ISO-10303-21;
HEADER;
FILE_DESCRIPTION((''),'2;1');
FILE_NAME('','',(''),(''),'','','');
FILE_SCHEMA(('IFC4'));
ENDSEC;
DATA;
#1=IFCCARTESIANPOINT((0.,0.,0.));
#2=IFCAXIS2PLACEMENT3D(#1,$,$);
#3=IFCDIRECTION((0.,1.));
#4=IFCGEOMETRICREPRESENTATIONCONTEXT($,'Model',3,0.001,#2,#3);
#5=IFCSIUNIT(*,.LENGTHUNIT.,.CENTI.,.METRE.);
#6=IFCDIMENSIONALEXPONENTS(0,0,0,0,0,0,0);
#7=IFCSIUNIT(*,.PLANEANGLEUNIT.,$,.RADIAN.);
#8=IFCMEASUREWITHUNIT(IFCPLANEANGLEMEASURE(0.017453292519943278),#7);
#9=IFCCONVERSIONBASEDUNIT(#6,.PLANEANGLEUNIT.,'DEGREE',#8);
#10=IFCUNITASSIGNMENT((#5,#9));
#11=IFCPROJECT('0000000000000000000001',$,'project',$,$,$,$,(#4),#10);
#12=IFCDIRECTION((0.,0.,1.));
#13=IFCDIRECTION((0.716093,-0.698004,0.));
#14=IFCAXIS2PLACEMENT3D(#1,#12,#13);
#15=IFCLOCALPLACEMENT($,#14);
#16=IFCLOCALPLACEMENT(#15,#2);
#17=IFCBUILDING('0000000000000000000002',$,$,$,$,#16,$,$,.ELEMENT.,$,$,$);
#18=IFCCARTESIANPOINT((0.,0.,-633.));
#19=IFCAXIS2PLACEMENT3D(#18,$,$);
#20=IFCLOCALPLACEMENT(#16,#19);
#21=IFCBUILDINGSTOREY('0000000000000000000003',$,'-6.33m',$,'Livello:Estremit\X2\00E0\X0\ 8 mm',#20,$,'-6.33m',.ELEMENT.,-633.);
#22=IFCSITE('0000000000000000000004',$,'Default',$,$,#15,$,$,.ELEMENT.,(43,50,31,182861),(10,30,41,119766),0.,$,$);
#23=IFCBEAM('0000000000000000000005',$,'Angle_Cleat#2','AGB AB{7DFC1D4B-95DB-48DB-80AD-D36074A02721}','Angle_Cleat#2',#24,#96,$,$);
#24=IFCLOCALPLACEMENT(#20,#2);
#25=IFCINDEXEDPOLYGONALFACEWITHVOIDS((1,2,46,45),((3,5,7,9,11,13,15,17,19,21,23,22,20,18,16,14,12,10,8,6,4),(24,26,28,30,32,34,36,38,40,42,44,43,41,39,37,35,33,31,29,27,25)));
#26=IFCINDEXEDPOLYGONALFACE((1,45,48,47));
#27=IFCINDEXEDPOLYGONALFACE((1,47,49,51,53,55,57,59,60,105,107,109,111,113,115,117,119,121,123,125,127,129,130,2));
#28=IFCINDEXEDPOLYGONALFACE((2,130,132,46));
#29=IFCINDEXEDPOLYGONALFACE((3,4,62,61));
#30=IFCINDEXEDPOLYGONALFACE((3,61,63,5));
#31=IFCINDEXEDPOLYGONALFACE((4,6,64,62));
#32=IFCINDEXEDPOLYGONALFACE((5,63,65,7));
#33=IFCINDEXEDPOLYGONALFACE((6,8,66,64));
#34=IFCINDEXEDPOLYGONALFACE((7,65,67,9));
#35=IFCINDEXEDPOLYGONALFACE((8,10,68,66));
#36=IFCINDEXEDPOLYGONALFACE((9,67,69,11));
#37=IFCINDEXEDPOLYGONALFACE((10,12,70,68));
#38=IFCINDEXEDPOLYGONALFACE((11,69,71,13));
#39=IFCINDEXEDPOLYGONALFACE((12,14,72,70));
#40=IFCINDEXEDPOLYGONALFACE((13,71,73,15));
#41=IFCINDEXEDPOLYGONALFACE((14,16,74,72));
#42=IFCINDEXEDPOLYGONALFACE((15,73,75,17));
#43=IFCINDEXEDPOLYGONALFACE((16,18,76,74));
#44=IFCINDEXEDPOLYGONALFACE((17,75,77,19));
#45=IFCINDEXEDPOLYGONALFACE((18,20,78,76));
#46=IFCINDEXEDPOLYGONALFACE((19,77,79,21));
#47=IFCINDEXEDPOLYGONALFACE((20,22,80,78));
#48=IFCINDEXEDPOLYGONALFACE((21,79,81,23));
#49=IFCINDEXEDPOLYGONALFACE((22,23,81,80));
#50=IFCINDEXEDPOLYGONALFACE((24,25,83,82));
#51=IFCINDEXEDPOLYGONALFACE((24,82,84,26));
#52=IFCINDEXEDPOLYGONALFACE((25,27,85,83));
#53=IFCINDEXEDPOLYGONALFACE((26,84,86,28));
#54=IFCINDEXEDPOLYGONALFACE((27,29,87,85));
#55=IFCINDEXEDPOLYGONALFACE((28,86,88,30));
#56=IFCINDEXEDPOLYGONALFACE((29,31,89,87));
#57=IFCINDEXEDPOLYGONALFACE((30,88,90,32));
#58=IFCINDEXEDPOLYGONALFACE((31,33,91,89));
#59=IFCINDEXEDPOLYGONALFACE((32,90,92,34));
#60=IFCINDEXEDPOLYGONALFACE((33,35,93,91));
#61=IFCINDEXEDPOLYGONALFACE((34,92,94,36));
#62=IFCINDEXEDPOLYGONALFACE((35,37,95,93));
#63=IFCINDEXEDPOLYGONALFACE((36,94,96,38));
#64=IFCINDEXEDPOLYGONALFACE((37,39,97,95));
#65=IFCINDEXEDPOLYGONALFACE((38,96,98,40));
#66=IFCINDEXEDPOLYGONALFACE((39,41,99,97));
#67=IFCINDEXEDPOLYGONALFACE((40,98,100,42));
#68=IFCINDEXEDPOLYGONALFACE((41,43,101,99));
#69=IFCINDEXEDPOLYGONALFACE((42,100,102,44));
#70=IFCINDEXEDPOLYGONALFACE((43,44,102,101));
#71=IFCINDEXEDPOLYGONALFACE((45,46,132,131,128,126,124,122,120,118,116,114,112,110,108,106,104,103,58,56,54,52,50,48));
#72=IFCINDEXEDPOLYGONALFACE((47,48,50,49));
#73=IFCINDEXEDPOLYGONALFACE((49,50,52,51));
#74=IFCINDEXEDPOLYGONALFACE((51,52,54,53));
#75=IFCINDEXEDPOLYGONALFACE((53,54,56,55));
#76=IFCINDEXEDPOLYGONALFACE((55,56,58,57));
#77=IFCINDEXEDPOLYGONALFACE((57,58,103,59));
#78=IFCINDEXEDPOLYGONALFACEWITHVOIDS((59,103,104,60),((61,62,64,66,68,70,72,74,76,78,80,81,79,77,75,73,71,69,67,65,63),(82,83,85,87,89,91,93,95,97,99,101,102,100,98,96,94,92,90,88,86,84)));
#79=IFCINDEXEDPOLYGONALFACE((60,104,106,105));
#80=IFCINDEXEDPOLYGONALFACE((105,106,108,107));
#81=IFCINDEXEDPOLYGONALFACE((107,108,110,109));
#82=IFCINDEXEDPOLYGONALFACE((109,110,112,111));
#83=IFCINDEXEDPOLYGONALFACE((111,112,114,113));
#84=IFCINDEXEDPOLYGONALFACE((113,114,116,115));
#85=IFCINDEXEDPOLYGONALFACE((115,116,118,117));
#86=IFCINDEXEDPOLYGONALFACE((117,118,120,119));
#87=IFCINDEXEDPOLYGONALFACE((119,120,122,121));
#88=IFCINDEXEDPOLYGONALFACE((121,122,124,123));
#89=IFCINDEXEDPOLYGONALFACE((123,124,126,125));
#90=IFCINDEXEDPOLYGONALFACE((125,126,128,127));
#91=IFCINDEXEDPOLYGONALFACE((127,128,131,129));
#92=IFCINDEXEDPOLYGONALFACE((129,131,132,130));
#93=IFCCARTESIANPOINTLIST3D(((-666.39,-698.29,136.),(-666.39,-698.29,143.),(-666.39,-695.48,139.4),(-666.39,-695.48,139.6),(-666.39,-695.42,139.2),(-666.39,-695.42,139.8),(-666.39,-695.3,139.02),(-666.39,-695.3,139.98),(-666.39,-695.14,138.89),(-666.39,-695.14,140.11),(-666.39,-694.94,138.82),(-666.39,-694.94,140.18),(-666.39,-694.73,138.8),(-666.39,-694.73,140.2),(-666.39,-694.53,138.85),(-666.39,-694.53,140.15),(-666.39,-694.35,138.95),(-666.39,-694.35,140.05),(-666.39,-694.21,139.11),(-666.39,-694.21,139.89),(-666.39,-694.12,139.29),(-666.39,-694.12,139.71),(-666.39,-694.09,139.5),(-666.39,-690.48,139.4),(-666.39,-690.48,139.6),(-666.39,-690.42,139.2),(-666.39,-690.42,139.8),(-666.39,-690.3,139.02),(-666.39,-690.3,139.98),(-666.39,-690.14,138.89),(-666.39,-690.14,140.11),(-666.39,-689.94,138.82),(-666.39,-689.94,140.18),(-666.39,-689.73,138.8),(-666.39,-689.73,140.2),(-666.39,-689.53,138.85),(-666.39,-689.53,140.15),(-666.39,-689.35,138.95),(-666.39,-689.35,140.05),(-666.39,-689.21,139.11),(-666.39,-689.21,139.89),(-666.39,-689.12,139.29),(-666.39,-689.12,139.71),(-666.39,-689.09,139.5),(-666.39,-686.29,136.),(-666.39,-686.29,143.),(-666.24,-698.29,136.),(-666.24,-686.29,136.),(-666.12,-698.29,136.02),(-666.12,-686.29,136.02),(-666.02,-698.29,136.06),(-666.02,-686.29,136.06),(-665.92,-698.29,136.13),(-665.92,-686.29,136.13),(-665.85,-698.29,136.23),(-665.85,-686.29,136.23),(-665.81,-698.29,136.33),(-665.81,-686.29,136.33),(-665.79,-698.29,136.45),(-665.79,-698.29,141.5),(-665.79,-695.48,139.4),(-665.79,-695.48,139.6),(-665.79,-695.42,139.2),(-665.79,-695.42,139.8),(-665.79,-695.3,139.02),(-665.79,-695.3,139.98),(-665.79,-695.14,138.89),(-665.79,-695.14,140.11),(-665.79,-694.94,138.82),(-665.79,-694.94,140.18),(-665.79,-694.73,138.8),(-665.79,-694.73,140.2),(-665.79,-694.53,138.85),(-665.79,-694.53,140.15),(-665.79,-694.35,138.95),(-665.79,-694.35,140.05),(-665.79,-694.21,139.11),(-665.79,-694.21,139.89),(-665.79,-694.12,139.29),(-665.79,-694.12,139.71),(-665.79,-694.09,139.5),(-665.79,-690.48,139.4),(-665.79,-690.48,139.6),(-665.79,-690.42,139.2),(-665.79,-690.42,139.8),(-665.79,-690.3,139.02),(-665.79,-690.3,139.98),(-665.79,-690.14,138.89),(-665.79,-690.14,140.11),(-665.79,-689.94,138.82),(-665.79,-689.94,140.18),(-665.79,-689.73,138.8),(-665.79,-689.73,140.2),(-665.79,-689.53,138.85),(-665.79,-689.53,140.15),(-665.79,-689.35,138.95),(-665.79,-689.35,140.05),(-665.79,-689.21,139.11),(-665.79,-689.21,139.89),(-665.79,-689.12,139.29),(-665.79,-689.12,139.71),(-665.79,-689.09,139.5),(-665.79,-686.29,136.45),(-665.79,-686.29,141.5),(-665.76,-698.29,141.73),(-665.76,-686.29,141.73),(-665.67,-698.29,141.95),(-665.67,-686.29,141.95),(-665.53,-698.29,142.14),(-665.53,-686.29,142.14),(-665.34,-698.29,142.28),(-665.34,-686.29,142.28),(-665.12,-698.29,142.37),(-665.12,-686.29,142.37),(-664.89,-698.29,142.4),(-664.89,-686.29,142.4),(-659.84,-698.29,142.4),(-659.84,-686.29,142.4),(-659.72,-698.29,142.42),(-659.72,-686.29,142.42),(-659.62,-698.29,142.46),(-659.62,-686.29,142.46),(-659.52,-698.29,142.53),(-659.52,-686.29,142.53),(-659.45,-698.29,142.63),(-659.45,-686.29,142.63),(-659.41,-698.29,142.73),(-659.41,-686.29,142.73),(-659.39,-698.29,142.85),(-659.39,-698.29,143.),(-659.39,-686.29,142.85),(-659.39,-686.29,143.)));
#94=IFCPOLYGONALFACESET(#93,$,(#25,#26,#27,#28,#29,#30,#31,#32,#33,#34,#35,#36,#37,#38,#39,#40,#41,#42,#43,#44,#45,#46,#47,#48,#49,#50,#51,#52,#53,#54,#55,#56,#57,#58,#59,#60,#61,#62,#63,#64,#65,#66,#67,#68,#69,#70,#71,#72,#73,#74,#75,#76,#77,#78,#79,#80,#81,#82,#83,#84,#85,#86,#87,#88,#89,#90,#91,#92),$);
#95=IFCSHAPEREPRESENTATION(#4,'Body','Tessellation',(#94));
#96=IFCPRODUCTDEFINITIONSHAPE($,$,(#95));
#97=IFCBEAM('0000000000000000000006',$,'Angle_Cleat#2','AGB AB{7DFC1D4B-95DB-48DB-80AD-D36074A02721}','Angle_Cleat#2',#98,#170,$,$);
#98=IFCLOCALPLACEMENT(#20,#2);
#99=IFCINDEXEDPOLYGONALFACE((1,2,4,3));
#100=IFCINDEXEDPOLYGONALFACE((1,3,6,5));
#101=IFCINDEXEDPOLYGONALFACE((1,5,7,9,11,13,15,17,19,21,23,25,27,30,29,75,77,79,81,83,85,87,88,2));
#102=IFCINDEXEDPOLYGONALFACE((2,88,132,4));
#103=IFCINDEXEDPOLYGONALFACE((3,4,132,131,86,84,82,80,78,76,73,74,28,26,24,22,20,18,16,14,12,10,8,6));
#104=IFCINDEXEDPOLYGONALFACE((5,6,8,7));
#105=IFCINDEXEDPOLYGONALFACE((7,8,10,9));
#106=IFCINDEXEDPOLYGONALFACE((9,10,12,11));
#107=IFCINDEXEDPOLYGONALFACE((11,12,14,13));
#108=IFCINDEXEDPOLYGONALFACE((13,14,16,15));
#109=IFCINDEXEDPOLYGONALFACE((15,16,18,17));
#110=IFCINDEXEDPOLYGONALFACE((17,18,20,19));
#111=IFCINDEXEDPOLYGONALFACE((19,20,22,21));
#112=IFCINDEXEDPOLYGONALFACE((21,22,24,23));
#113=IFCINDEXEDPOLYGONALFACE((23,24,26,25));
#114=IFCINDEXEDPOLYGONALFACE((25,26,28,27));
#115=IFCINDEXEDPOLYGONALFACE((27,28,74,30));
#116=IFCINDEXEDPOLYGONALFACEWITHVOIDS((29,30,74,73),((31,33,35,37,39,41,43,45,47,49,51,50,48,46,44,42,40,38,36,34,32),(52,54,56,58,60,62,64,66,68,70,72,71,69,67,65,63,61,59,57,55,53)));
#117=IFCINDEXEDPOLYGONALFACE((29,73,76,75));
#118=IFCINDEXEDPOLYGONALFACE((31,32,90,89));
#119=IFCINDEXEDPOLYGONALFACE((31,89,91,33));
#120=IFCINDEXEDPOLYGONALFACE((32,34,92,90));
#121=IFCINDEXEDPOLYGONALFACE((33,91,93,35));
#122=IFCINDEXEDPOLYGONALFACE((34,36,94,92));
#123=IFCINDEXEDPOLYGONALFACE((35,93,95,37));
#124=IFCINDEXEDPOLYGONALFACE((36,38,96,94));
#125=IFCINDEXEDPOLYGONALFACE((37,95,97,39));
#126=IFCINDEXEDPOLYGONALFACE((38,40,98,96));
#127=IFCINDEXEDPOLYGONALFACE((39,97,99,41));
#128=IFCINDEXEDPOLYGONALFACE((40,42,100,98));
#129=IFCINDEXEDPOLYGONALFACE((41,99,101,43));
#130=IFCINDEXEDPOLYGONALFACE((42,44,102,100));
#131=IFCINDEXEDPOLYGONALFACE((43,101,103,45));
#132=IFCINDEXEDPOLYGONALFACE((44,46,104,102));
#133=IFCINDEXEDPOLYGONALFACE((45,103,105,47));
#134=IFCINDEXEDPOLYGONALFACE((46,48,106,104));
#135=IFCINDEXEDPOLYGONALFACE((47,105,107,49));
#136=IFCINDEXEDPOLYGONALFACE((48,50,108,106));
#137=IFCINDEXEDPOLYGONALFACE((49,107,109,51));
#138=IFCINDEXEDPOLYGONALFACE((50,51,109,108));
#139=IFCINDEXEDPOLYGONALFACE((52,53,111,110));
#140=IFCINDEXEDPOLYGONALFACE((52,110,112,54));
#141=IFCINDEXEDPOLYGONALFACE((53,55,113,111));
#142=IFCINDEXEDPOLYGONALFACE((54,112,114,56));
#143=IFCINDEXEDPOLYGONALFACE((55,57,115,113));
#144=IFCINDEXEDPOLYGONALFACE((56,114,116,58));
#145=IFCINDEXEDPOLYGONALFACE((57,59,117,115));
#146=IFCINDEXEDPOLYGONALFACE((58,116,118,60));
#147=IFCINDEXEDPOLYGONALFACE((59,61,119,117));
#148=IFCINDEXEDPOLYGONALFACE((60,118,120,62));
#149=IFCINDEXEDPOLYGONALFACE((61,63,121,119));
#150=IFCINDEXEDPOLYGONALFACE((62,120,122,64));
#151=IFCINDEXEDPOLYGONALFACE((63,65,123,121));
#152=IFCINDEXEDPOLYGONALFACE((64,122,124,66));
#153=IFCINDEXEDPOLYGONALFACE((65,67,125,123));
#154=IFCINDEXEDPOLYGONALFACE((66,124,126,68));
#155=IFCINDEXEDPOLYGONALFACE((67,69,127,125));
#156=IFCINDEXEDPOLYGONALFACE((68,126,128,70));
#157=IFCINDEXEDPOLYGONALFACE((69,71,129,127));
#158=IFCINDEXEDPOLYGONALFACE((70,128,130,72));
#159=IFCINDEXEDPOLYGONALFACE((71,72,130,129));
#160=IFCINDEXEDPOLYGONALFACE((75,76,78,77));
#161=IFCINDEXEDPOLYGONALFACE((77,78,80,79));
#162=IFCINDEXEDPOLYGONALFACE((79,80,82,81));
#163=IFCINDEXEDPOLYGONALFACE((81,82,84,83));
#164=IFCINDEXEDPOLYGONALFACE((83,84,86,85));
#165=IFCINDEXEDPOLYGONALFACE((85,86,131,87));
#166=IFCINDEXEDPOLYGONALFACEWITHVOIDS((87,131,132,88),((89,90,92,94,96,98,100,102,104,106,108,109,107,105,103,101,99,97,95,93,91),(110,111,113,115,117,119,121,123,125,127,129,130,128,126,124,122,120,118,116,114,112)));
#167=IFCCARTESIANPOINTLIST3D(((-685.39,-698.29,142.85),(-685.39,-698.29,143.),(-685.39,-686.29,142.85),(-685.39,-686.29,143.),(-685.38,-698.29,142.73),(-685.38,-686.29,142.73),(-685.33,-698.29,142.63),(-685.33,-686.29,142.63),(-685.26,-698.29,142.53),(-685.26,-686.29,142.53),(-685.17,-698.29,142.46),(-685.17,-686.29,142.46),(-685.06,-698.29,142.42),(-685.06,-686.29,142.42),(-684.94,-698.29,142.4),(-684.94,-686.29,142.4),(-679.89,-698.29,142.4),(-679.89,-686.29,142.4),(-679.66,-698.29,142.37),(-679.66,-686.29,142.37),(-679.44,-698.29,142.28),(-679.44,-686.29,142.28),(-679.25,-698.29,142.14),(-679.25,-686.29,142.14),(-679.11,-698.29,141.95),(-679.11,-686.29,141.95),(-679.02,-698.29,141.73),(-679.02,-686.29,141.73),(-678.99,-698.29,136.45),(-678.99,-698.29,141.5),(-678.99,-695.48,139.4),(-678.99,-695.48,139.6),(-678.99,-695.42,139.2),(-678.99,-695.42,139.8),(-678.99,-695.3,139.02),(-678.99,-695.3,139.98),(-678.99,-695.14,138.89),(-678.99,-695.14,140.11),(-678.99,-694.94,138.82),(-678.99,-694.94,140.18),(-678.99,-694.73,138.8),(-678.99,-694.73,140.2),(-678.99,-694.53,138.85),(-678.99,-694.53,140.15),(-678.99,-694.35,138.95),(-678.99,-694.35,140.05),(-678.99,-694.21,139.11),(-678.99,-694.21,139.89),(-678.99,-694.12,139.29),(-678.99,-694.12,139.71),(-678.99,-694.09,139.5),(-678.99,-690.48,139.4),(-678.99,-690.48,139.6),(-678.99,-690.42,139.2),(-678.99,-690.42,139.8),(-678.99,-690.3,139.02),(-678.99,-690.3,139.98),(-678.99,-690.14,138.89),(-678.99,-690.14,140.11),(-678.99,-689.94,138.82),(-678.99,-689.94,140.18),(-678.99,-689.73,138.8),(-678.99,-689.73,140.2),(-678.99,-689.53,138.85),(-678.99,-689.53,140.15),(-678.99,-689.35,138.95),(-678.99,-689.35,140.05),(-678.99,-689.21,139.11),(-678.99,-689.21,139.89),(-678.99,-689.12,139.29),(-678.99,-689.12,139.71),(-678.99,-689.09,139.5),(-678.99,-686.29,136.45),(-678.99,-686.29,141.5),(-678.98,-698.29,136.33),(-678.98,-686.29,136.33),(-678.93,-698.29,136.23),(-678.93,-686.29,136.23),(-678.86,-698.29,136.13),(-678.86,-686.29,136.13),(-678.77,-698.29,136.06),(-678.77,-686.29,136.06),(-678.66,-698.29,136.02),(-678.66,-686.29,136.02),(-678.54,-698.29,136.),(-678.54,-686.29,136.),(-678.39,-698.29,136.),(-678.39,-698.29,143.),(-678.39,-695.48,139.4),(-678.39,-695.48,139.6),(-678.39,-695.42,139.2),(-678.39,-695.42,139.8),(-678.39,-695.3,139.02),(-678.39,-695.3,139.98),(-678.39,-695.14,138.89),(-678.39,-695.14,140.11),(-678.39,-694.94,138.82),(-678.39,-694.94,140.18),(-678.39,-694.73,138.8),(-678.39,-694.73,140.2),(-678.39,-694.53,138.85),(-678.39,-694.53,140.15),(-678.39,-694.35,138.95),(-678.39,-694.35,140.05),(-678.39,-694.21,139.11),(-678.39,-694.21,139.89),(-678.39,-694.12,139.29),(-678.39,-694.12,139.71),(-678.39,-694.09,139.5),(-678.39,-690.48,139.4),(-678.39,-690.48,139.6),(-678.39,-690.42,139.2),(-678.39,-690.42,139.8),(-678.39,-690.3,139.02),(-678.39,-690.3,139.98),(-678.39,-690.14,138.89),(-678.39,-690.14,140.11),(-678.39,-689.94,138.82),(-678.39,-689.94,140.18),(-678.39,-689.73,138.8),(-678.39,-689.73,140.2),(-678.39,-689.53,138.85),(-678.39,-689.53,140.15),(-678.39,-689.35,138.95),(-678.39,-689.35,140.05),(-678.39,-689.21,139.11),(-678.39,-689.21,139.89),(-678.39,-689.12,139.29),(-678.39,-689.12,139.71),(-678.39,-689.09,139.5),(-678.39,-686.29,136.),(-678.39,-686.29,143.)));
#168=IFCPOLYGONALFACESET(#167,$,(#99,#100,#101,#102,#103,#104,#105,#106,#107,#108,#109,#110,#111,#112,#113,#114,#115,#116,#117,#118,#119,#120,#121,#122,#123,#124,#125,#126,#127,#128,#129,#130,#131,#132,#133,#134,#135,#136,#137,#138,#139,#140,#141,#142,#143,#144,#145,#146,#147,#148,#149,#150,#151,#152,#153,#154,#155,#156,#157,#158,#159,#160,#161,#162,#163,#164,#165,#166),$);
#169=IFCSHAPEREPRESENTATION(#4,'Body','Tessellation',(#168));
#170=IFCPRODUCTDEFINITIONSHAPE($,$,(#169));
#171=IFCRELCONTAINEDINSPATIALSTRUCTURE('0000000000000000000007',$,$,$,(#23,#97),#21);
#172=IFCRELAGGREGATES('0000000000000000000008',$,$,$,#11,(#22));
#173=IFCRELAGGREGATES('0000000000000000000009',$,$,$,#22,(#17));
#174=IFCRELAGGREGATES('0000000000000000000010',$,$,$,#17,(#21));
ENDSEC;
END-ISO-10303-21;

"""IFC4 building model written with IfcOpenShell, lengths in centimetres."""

from ifc_helpers import new_model, entity, si_unit, converted_unit, direction, frame, frame_2d, origin, place, context, project, spatial, circle, l_section, extrude, element, save


model = new_model("IFC4")

# Units and contexts
model_context = context("Model", 3, precision=0.001, world=origin(), true_north=direction((0.0, 1.0)))
ifc_project = project(units=[si_unit("LENGTHUNIT", "METRE", prefix="CENTI"), converted_unit("PLANEANGLEUNIT", "DEGREE", entity("IfcPlaneAngleMeasure", 0.017453292519943278), si_unit("PLANEANGLEUNIT", "RADIAN"), dimensions=[0, 0, 0, 0, 0, 0, 0])], contexts=[model_context])

# Site, building, storey
site_placement = place(None, frame((0.0, 0.0, 0.0), z_axis=(0.0, 0.0, 1.0), x_axis=(0.716093, -0.698004, 0.0)))
site = spatial("IfcSite", under=ifc_project, at=site_placement, Name="Default", CompositionType="ELEMENT", RefLatitude=(43, 50, 31, 182861), RefLongitude=(10, 30, 41, 119766), RefElevation=0.0)
building_placement = place(site_placement, origin())
building = spatial("IfcBuilding", under=site, at=building_placement, CompositionType="ELEMENT")
storey_placement = place(building_placement, frame((0.0, 0.0, -633.0)))
storey = spatial("IfcBuildingStorey", under=building, at=storey_placement, Name="-6.33m", ObjectType="Livello:Estremità 8 mm", LongName="-6.33m", CompositionType="ELEMENT", Elevation=-633.0)

# Beams, openings
beam_1_placement = place(storey_placement, frame((-664.46, -686.29, 141.07), z_axis=(0.0, 1.0, 0.0), x_axis=(1.0, 0.0, 0.0)))
beam_1 = element("IfcBeam", 1, at=beam_1_placement, inside=storey, Name="Angle_Cleat#2", Description="AGB AB{7DFC1D4B-95DB-48DB-80AD-D36074A02721}", ObjectType="Angle_Cleat#2", context=model_context, shape_type="SweptSolid", body=[
    extrude(l_section(Depth=7.0, Width=7.0, Thickness=0.6, FilletRadius=0.9, EdgeRadius=0.45, at=frame_2d((1.57, 1.57))), origin(), (0.0, 0.0, -1.0), 12.0),
])
opening_1_placement = place(beam_1_placement, frame((-1.98, 1.57, -6.0), z_axis=(1.0, 0.0, 0.0), x_axis=(0.0, 0.0, 1.0)))
element("IfcOpeningElement", 2, at=opening_1_placement, cuts=beam_1, ObjectType="Opening", context=model_context, shape_type="SweptSolid", body=[
    extrude(circle(Radius=0.7, at=frame_2d((2.5, 0.0), x_axis=(1.0, 0.0))), origin(), (0.0, 0.0, 1.0), 0.7),
])
opening_2_placement = place(beam_1_placement, frame((-1.98, 1.57, -6.0), z_axis=(1.0, 0.0, 0.0), x_axis=(0.0, 0.0, 1.0)))
element("IfcOpeningElement", 3, at=opening_2_placement, cuts=beam_1, ObjectType="Opening", context=model_context, shape_type="SweptSolid", body=[
    extrude(circle(Radius=0.7, at=frame_2d((-2.5, 0.0), x_axis=(1.0, 0.0))), origin(), (0.0, 0.0, 1.0), 0.7),
])
beam_2_placement = place(storey_placement, frame((-680.32, -698.29, 141.07), z_axis=(0.0, -1.0, 0.0), x_axis=(-1.0, 0.0, 0.0)))
beam_2 = element("IfcBeam", 4, at=beam_2_placement, inside=storey, Name="Angle_Cleat#2", Description="AGB AB{7DFC1D4B-95DB-48DB-80AD-D36074A02721}", ObjectType="Angle_Cleat#2", context=model_context, shape_type="SweptSolid", body=[
    extrude(l_section(Depth=7.0, Width=7.0, Thickness=0.6, FilletRadius=0.9, EdgeRadius=0.45, at=frame_2d((1.57, 1.57))), origin(), (0.0, 0.0, -1.0), 12.0),
])
opening_3_placement = place(beam_2_placement, frame((-1.28, 1.57, -6.0), z_axis=(-1.0, 0.0, 0.0), x_axis=(0.0, 0.0, -1.0)))
element("IfcOpeningElement", 5, at=opening_3_placement, cuts=beam_2, ObjectType="Opening", context=model_context, shape_type="SweptSolid", body=[
    extrude(circle(Radius=0.7, at=frame_2d((2.5, 0.0), x_axis=(1.0, 0.0))), origin(), (0.0, 0.0, 1.0), 0.7),
])
opening_4_placement = place(beam_2_placement, frame((-1.28, 1.57, -6.0), z_axis=(-1.0, 0.0, 0.0), x_axis=(0.0, 0.0, -1.0)))
element("IfcOpeningElement", 6, at=opening_4_placement, cuts=beam_2, ObjectType="Opening", context=model_context, shape_type="SweptSolid", body=[
    extrude(circle(Radius=0.7, at=frame_2d((-2.5, 0.0), x_axis=(1.0, 0.0))), origin(), (0.0, 0.0, 1.0), 0.7),
])

save(model, "model.ifc")
